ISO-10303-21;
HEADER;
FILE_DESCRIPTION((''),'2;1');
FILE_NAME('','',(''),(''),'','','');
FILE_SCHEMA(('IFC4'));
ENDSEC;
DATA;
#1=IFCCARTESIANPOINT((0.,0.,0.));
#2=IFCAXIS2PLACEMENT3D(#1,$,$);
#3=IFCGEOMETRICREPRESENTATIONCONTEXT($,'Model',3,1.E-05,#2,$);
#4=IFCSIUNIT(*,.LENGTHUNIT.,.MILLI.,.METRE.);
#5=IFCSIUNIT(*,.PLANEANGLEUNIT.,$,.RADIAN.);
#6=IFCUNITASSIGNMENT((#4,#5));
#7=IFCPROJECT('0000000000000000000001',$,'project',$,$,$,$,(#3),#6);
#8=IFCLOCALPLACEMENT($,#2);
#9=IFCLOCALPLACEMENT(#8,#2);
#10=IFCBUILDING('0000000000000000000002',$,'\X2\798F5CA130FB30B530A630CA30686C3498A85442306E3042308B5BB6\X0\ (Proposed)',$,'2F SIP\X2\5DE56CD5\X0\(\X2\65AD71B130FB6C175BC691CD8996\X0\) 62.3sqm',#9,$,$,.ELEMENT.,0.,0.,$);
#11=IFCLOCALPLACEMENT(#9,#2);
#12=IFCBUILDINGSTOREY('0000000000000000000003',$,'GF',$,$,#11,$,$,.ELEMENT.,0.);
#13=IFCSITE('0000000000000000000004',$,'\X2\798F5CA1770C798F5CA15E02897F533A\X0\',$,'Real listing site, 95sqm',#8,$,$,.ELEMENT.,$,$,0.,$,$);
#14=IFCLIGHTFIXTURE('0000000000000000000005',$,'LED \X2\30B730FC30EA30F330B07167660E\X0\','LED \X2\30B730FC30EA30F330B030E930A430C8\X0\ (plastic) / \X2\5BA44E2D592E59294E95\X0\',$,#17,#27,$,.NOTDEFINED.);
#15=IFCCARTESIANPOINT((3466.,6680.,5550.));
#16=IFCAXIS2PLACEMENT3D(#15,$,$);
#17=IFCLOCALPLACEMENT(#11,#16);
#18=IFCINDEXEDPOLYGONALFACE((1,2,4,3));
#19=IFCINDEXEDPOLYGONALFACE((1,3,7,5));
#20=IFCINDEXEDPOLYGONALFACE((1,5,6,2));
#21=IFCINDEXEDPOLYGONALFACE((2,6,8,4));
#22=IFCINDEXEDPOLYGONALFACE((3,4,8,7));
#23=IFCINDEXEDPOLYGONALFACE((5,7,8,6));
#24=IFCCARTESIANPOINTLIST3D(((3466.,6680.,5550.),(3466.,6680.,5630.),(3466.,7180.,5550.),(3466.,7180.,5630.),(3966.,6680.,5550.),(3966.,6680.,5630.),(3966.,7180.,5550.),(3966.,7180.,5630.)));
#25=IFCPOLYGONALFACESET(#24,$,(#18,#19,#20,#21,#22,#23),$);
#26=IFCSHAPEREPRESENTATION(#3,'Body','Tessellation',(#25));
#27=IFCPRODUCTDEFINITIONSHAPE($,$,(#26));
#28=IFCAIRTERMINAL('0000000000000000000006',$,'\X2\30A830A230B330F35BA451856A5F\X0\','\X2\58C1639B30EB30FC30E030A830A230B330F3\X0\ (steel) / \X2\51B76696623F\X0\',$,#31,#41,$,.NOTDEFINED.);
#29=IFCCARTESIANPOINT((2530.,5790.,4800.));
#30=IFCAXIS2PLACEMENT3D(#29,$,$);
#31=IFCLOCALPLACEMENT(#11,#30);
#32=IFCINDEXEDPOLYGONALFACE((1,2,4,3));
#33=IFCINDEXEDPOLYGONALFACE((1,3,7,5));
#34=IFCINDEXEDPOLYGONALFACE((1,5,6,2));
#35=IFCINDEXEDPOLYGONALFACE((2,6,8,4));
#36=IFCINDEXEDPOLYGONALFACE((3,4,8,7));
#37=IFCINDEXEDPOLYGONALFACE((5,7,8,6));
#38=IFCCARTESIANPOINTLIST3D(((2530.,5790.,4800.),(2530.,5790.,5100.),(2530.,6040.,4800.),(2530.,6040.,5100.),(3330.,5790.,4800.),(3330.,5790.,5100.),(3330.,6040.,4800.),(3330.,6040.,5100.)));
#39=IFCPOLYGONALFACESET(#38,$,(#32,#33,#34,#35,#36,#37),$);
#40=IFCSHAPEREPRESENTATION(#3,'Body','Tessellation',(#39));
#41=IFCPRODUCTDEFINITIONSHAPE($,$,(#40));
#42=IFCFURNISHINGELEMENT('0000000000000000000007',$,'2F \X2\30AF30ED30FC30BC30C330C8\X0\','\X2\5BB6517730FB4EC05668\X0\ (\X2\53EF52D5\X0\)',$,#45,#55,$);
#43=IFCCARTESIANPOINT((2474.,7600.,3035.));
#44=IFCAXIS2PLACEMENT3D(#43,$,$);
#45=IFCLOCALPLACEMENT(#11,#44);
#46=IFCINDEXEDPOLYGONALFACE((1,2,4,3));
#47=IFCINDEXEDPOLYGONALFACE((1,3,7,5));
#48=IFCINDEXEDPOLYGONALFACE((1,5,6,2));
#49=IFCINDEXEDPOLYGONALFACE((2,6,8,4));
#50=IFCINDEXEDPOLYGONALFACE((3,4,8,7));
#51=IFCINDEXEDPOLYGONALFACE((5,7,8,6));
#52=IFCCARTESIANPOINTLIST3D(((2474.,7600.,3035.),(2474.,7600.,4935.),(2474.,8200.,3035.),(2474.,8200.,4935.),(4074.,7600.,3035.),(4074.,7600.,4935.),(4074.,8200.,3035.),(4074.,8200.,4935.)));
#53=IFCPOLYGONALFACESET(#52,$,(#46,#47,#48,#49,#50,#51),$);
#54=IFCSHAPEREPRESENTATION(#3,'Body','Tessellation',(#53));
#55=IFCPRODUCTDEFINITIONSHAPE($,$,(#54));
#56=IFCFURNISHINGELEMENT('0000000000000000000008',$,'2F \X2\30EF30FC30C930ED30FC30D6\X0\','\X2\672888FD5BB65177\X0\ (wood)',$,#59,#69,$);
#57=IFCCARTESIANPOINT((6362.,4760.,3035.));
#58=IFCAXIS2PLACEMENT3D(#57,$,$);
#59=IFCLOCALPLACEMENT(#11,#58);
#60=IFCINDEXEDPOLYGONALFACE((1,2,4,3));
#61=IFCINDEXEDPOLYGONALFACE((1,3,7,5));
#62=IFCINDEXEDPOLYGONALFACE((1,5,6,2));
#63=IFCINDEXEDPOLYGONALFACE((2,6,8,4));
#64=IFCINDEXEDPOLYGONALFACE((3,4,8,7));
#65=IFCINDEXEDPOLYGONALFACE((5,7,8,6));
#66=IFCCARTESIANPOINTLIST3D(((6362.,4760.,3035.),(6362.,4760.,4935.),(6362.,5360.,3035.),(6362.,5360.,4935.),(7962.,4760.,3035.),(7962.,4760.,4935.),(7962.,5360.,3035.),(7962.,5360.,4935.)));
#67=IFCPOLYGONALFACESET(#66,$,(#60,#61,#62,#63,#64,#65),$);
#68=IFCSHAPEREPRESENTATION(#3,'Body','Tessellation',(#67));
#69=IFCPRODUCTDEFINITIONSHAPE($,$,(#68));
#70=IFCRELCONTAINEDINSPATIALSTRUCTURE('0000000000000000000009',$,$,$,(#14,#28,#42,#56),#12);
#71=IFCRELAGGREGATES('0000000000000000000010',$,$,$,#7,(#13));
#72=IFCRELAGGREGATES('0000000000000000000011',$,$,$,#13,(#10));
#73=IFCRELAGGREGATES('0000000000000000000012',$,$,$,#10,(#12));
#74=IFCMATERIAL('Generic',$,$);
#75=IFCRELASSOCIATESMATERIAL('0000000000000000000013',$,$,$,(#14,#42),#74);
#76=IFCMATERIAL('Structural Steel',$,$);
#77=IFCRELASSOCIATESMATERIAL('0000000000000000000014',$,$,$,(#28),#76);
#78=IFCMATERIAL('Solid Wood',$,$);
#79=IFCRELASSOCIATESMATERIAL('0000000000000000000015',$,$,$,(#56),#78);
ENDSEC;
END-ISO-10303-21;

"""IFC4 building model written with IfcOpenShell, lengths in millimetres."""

from ifc_helpers import new_model, si_unit, frame, frame_2d, origin, place, context, project, spatial, rectangle, extrude, material, element, save


model = new_model("IFC4")

# Units and contexts
model_context = context("Model", 3, precision=1e-05, world=origin())
ifc_project = project(units=[si_unit("LENGTHUNIT", "METRE", prefix="MILLI"), si_unit("PLANEANGLEUNIT", "RADIAN")], contexts=[model_context])

# Site, building, storey
site_placement = place(None, origin())
site = spatial("IfcSite", under=ifc_project, at=site_placement, Name="福岡県福岡市西区", ObjectType="Real listing site, 95sqm", CompositionType="ELEMENT", RefElevation=0.0)
building_placement = place(site_placement, origin())
building = spatial("IfcBuilding", under=site, at=building_placement, Name="福岡・サウナと水風呂のある家 (Proposed)", ObjectType="2F SIP工法(断熱・気密重視) 62.3sqm", CompositionType="ELEMENT", ElevationOfRefHeight=0.0, ElevationOfTerrain=0.0)
storey_placement = place(building_placement, origin())
storey = spatial("IfcBuildingStorey", under=building, at=storey_placement, Name="GF", CompositionType="ELEMENT", Elevation=0.0)

# Shared definitions
ifc_material_1 = material(Name="Solid Wood")

# Shared definitions
ifc_material_2 = material(Name="Generic")

# Shared definitions
ifc_material_3 = material(Name="Structural Steel")

# Light fixture
light_fixture_1_placement = place(storey_placement, frame((3466.0, 6680.0, 5550.0)))
element("IfcLightFixture", 1, at=light_fixture_1_placement, inside=storey, material=ifc_material_2, Name="LED シーリング照明", Description="LED シーリングライト (plastic) / 室中央天井", PredefinedType="NOTDEFINED", context=model_context, shape_type="SweptSolid", body=[
    extrude(rectangle(XDim=500.0, YDim=500.0, at=frame_2d((250.0, 250.0))), frame((3466.0, 6680.0, 5550.0)), (0.0, 0.0, 1.0), 80.0),
])

# Air terminal
air_terminal_placement = place(storey_placement, frame((2530.0, 5790.0, 4800.0)))
element("IfcAirTerminal", 2, at=air_terminal_placement, inside=storey, material=ifc_material_3, Name="エアコン室内機", Description="壁掛ルームエアコン (steel) / 冷暖房", PredefinedType="NOTDEFINED", context=model_context, shape_type="SweptSolid", body=[
    extrude(rectangle(XDim=800.0, YDim=250.0, at=frame_2d((400.0, 125.0))), frame((2530.0, 5790.0, 4800.0)), (0.0, 0.0, 1.0), 300.0),
])

# Furnishing elements
furnishing_1_placement = place(storey_placement, frame((2474.0, 7600.0, 3035.0)))
element("IfcFurnishingElement", 3, at=furnishing_1_placement, inside=storey, material=ifc_material_2, Name="2F クローゼット", Description="家具・什器 (可動)", context=model_context, shape_type="SweptSolid", body=[
    extrude(rectangle(XDim=1600.0, YDim=600.0, at=frame_2d((800.0, 300.0))), frame((2474.0, 7600.0, 3035.0)), (0.0, 0.0, 1.0), 1900.0),
])
furnishing_2_placement = place(storey_placement, frame((6362.0, 4760.0, 3035.0)))
element("IfcFurnishingElement", 4, at=furnishing_2_placement, inside=storey, material=ifc_material_1, Name="2F ワードローブ", Description="木製家具 (wood)", context=model_context, shape_type="SweptSolid", body=[
    extrude(rectangle(XDim=1600.0, YDim=600.0, at=frame_2d((800.0, 300.0))), frame((6362.0, 4760.0, 3035.0)), (0.0, 0.0, 1.0), 1900.0),
])

save(model, "model.ifc")
